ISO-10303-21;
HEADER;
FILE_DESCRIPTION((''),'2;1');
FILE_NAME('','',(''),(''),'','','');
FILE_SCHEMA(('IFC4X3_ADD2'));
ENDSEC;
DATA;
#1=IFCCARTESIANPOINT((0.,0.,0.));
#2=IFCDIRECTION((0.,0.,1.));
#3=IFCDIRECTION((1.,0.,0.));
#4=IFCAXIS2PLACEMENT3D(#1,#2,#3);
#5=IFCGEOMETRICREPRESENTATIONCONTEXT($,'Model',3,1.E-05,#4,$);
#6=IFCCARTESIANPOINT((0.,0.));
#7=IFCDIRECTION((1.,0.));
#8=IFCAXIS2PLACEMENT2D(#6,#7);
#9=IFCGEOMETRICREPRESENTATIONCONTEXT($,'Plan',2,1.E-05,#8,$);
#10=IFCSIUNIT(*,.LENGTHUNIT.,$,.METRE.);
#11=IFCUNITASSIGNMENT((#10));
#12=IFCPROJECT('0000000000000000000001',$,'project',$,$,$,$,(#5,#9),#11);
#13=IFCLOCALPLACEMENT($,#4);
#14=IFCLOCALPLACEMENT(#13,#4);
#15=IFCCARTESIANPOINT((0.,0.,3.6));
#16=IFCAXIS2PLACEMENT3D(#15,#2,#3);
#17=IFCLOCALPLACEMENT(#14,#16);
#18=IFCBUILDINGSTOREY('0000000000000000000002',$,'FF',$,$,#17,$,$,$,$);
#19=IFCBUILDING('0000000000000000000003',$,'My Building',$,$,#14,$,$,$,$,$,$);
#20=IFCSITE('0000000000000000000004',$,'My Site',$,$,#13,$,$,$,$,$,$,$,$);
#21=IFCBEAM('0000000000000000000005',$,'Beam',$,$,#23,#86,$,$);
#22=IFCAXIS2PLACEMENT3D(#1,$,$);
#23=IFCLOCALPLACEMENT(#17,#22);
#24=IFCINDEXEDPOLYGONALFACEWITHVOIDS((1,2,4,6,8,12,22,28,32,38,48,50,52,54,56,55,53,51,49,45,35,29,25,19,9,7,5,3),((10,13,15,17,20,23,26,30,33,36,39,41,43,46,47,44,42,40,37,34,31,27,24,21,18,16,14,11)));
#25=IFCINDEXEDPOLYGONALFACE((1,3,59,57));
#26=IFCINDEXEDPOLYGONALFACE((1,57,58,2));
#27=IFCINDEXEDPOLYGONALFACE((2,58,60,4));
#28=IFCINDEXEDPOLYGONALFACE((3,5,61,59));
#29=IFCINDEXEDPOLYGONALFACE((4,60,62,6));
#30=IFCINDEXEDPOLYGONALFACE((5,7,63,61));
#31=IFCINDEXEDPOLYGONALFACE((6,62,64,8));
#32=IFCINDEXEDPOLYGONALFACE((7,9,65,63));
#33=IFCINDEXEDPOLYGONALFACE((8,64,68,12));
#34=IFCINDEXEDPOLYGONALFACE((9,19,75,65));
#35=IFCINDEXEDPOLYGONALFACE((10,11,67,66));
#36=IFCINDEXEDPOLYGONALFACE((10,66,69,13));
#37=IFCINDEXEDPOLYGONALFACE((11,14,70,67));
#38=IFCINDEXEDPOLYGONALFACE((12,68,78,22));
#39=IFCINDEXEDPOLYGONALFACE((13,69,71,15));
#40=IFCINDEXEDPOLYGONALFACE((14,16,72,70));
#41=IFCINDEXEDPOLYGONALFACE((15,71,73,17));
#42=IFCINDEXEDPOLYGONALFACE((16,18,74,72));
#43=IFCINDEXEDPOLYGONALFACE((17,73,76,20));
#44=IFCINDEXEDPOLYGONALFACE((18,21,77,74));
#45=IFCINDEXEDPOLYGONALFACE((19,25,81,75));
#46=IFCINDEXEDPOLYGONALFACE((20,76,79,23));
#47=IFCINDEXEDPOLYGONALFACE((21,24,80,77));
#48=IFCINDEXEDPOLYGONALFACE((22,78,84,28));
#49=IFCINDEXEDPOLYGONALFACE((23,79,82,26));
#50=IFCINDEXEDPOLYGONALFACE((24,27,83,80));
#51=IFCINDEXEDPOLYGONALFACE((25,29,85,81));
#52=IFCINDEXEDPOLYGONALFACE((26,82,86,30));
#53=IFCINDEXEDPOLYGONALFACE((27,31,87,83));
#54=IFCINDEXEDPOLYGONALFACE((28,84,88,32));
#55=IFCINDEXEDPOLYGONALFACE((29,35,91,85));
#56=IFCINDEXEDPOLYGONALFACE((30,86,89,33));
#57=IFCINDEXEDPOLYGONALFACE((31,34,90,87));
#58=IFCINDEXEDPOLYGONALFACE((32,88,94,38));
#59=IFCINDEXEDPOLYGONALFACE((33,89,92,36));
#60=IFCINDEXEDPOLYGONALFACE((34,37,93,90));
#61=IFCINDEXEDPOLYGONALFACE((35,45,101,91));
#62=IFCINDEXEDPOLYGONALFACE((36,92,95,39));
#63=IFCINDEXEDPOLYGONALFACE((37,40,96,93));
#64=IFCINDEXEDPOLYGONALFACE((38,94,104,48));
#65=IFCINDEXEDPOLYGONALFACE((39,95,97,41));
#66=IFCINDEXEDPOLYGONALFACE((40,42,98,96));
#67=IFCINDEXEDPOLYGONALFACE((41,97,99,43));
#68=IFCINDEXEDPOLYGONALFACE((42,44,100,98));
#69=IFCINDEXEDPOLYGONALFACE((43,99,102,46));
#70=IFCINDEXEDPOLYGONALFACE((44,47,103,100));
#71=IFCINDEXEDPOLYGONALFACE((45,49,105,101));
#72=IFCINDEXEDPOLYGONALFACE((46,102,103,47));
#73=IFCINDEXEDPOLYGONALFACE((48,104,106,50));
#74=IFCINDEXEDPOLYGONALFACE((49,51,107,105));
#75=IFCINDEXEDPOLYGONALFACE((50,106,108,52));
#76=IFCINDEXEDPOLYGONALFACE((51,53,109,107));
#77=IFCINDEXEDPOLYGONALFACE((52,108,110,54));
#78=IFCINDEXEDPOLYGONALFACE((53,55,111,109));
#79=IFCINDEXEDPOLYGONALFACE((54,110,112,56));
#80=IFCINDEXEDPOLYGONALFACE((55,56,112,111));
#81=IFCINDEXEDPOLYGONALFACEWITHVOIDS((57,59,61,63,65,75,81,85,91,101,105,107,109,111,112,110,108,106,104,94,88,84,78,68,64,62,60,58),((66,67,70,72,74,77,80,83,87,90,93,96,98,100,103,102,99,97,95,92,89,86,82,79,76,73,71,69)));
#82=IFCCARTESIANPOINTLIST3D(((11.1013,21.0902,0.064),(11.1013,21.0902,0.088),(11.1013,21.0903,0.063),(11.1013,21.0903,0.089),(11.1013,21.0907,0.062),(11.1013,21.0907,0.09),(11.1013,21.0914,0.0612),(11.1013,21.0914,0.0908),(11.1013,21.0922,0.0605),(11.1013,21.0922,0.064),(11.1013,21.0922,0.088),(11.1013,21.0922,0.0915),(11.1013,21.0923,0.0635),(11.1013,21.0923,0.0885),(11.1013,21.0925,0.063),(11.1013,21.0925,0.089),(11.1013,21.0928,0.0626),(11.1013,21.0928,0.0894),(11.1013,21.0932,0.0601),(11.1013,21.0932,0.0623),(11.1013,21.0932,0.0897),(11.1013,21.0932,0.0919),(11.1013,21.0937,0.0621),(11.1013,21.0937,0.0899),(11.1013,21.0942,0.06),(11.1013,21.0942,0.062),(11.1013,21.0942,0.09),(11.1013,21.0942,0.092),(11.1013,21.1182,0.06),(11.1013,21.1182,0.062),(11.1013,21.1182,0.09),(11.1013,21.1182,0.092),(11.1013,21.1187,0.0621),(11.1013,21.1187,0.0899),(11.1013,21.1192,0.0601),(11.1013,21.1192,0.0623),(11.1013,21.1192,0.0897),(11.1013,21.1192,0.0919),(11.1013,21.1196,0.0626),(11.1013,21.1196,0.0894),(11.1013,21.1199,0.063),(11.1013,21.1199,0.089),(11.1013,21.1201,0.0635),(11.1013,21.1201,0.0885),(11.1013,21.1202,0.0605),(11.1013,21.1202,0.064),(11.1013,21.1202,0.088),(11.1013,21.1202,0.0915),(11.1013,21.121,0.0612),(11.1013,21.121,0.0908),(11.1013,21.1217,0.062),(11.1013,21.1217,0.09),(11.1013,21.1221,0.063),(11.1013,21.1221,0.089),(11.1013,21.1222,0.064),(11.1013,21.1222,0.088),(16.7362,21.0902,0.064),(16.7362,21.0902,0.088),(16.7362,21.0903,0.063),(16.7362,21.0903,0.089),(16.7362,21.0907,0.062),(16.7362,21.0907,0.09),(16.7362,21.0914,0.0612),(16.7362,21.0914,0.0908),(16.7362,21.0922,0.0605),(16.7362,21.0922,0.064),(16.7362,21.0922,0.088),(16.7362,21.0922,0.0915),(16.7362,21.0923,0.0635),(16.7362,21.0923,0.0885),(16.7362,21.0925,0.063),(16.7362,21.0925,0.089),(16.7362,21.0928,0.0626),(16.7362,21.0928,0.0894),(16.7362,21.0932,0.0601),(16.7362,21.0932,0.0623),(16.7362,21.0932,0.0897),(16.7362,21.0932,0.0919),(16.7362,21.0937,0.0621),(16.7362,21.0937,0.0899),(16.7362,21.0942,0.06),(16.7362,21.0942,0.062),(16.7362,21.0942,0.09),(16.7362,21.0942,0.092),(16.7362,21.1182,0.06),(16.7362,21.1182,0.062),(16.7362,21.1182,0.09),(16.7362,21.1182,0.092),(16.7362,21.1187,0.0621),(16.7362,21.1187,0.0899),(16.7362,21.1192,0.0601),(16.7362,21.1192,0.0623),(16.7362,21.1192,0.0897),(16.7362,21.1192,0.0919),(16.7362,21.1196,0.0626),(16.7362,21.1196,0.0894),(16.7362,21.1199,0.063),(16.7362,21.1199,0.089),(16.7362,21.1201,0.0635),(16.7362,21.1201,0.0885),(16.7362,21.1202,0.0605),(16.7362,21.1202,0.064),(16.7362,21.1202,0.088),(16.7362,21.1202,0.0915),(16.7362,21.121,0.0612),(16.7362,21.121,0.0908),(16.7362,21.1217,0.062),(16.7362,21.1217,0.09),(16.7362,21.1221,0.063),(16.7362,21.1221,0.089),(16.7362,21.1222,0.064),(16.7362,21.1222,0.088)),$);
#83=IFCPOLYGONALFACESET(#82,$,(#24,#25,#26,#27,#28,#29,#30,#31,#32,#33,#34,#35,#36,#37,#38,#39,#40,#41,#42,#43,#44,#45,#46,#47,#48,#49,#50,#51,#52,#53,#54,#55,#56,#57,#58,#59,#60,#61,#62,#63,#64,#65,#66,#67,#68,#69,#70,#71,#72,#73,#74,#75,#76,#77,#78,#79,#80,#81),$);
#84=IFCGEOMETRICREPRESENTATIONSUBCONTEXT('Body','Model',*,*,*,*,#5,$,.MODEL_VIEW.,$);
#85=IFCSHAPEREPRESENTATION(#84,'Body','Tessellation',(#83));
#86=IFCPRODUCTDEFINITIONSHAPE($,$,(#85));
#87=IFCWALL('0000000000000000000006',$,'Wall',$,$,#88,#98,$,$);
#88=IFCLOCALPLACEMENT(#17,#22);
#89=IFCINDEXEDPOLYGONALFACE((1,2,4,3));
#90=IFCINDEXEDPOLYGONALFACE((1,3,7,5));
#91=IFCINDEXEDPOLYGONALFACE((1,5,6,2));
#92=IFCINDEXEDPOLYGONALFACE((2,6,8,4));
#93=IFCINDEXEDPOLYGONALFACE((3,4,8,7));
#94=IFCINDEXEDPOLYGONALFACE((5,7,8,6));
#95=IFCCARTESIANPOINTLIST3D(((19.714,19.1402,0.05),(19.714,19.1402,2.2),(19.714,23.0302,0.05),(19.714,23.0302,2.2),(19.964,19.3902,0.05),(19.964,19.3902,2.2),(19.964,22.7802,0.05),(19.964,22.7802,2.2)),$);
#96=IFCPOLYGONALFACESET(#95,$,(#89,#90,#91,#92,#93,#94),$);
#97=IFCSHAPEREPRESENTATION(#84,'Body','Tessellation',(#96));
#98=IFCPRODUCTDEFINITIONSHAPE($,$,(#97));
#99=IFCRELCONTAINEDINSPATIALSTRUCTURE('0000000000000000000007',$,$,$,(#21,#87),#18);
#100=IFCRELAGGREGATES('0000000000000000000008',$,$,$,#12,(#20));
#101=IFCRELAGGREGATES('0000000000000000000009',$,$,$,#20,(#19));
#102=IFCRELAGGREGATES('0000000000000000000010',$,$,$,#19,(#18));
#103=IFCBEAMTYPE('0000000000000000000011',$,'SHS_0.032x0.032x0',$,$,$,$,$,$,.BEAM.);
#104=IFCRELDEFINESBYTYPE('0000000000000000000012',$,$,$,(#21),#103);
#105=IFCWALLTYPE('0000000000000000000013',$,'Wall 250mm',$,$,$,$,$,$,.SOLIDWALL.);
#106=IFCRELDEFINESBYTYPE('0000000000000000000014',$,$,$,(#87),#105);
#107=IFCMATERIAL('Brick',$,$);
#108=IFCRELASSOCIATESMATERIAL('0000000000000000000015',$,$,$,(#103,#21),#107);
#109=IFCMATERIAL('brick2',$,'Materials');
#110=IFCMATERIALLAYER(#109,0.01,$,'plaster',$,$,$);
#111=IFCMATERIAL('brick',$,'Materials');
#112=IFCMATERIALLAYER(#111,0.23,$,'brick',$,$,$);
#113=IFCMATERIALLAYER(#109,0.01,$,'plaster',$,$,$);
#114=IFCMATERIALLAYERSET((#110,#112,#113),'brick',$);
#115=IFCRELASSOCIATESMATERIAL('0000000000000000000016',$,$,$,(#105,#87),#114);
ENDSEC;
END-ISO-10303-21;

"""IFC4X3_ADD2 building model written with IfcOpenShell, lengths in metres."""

from ifc_helpers import new_model, si_unit, frame, origin_with_axes, origin_2d_with_axis, place, context, subcontext, project, spatial, line, indexed_curve, hollow_rectangle, outline, extrude, material, layer, layer_set, layer_usage, material_profile, profile_set, profile_usage, type_object, element, save


model = new_model("IFC4X3_ADD2")

# Units and contexts
model_context = context("Model", 3, precision=1e-05, world=origin_with_axes())
plan_context = context("Plan", 2, precision=1e-05, world=origin_2d_with_axis())
body_context_1 = subcontext(model_context, "Body", "Model", "MODEL_VIEW")
ifc_project = project(units=[si_unit("LENGTHUNIT", "METRE")], contexts=[model_context, plan_context])

# Site, building, storey
site_placement = place(None, origin_with_axes())
site = spatial("IfcSite", under=ifc_project, at=site_placement, Name="My Site")
building_placement = place(site_placement, origin_with_axes())
building = spatial("IfcBuilding", under=site, at=building_placement, Name="My Building")
storey_placement = place(building_placement, frame((0.0, 0.0, 3.6), z_axis=(0.0, 0.0, 1.0), x_axis=(1.0, 0.0, 0.0)))
storey = spatial("IfcBuildingStorey", under=building, at=storey_placement, Name="FF")

# Beam
ifc_material_1 = material(Name="Brick")
ifc_material_profile_1 = material_profile(ifc_material_1, hollow_rectangle(XDim=0.032, YDim=0.032, WallThickness=0.002, InnerFilletRadius=0.002, OuterFilletRadius=0.004))
ifc_profile_set_1 = profile_set([ifc_material_profile_1])
beam_type_1 = type_object("IfcBeamType", Name="SHS_0.032x0.032x0", PredefinedType="BEAM", material=ifc_profile_set_1)
ifc_material_profile_2 = material_profile(ifc_material_1, hollow_rectangle(XDim=0.032, YDim=0.032, WallThickness=0.002, InnerFilletRadius=0.002, OuterFilletRadius=0.004))
ifc_profile_set_2 = profile_set([ifc_material_profile_2])
ifc_profile_usage_1 = profile_usage(ifc_profile_set_2, cardinal=5)
beam_1_placement = place(storey_placement, frame((11.1013, 21.1062, 0.076), z_axis=(1.0, 0.0, 0.0), x_axis=(0.0, 1.0, 0.0)))
element("IfcBeam", 1, at=beam_1_placement, inside=storey, type_object=beam_type_1, material=ifc_profile_usage_1, Name="Beam", context=body_context_1, shape_type="SweptSolid", body=[
    extrude(hollow_rectangle(XDim=0.032, YDim=0.032, WallThickness=0.002, InnerFilletRadius=0.002, OuterFilletRadius=0.004), origin_with_axes(), (0.0, 0.0, 1.0), 5.635),
])

# Wall
ifc_material_2 = material(Name="brick2", Category="Materials")
ifc_layer_1 = layer(ifc_material_2, 0.01, Name="plaster")
ifc_material_3 = material(Name="brick", Category="Materials")
ifc_layer_2 = layer(ifc_material_3, 0.23, Name="brick")
ifc_layer_3 = layer(ifc_material_2, 0.01, Name="plaster")
ifc_layer_set_1 = layer_set([ifc_layer_1, ifc_layer_2, ifc_layer_3], Name="brick")
ifc_layer_usage_1 = layer_usage(ifc_layer_set_1, "AXIS2", "NEGATIVE", 0.0)
wall_type_1 = type_object("IfcWallType", Name="Wall 250mm", PredefinedType="SOLIDWALL", material=ifc_layer_set_1)
wall_1_placement = place(storey_placement, frame((19.714, 19.1402, 0.05), z_axis=(0.0, 0.0, 1.0), x_axis=(0.000001, 1.0, 0.0)))
element("IfcWall", 2, at=wall_1_placement, inside=storey, type_object=wall_type_1, material=ifc_layer_usage_1, Name="Wall", context=body_context_1, shape_type="SweptSolid", body=[
    extrude(outline(indexed_curve([(0.25, -0.25), (0.0, 0.0), (3.89, 0.0), (3.64, -0.25)], segments=[line(1, 2, 3, 4, 1)])), origin_with_axes(), (0.0, 0.0, 1.0), 2.15),
])

save(model, "model.ifc")
